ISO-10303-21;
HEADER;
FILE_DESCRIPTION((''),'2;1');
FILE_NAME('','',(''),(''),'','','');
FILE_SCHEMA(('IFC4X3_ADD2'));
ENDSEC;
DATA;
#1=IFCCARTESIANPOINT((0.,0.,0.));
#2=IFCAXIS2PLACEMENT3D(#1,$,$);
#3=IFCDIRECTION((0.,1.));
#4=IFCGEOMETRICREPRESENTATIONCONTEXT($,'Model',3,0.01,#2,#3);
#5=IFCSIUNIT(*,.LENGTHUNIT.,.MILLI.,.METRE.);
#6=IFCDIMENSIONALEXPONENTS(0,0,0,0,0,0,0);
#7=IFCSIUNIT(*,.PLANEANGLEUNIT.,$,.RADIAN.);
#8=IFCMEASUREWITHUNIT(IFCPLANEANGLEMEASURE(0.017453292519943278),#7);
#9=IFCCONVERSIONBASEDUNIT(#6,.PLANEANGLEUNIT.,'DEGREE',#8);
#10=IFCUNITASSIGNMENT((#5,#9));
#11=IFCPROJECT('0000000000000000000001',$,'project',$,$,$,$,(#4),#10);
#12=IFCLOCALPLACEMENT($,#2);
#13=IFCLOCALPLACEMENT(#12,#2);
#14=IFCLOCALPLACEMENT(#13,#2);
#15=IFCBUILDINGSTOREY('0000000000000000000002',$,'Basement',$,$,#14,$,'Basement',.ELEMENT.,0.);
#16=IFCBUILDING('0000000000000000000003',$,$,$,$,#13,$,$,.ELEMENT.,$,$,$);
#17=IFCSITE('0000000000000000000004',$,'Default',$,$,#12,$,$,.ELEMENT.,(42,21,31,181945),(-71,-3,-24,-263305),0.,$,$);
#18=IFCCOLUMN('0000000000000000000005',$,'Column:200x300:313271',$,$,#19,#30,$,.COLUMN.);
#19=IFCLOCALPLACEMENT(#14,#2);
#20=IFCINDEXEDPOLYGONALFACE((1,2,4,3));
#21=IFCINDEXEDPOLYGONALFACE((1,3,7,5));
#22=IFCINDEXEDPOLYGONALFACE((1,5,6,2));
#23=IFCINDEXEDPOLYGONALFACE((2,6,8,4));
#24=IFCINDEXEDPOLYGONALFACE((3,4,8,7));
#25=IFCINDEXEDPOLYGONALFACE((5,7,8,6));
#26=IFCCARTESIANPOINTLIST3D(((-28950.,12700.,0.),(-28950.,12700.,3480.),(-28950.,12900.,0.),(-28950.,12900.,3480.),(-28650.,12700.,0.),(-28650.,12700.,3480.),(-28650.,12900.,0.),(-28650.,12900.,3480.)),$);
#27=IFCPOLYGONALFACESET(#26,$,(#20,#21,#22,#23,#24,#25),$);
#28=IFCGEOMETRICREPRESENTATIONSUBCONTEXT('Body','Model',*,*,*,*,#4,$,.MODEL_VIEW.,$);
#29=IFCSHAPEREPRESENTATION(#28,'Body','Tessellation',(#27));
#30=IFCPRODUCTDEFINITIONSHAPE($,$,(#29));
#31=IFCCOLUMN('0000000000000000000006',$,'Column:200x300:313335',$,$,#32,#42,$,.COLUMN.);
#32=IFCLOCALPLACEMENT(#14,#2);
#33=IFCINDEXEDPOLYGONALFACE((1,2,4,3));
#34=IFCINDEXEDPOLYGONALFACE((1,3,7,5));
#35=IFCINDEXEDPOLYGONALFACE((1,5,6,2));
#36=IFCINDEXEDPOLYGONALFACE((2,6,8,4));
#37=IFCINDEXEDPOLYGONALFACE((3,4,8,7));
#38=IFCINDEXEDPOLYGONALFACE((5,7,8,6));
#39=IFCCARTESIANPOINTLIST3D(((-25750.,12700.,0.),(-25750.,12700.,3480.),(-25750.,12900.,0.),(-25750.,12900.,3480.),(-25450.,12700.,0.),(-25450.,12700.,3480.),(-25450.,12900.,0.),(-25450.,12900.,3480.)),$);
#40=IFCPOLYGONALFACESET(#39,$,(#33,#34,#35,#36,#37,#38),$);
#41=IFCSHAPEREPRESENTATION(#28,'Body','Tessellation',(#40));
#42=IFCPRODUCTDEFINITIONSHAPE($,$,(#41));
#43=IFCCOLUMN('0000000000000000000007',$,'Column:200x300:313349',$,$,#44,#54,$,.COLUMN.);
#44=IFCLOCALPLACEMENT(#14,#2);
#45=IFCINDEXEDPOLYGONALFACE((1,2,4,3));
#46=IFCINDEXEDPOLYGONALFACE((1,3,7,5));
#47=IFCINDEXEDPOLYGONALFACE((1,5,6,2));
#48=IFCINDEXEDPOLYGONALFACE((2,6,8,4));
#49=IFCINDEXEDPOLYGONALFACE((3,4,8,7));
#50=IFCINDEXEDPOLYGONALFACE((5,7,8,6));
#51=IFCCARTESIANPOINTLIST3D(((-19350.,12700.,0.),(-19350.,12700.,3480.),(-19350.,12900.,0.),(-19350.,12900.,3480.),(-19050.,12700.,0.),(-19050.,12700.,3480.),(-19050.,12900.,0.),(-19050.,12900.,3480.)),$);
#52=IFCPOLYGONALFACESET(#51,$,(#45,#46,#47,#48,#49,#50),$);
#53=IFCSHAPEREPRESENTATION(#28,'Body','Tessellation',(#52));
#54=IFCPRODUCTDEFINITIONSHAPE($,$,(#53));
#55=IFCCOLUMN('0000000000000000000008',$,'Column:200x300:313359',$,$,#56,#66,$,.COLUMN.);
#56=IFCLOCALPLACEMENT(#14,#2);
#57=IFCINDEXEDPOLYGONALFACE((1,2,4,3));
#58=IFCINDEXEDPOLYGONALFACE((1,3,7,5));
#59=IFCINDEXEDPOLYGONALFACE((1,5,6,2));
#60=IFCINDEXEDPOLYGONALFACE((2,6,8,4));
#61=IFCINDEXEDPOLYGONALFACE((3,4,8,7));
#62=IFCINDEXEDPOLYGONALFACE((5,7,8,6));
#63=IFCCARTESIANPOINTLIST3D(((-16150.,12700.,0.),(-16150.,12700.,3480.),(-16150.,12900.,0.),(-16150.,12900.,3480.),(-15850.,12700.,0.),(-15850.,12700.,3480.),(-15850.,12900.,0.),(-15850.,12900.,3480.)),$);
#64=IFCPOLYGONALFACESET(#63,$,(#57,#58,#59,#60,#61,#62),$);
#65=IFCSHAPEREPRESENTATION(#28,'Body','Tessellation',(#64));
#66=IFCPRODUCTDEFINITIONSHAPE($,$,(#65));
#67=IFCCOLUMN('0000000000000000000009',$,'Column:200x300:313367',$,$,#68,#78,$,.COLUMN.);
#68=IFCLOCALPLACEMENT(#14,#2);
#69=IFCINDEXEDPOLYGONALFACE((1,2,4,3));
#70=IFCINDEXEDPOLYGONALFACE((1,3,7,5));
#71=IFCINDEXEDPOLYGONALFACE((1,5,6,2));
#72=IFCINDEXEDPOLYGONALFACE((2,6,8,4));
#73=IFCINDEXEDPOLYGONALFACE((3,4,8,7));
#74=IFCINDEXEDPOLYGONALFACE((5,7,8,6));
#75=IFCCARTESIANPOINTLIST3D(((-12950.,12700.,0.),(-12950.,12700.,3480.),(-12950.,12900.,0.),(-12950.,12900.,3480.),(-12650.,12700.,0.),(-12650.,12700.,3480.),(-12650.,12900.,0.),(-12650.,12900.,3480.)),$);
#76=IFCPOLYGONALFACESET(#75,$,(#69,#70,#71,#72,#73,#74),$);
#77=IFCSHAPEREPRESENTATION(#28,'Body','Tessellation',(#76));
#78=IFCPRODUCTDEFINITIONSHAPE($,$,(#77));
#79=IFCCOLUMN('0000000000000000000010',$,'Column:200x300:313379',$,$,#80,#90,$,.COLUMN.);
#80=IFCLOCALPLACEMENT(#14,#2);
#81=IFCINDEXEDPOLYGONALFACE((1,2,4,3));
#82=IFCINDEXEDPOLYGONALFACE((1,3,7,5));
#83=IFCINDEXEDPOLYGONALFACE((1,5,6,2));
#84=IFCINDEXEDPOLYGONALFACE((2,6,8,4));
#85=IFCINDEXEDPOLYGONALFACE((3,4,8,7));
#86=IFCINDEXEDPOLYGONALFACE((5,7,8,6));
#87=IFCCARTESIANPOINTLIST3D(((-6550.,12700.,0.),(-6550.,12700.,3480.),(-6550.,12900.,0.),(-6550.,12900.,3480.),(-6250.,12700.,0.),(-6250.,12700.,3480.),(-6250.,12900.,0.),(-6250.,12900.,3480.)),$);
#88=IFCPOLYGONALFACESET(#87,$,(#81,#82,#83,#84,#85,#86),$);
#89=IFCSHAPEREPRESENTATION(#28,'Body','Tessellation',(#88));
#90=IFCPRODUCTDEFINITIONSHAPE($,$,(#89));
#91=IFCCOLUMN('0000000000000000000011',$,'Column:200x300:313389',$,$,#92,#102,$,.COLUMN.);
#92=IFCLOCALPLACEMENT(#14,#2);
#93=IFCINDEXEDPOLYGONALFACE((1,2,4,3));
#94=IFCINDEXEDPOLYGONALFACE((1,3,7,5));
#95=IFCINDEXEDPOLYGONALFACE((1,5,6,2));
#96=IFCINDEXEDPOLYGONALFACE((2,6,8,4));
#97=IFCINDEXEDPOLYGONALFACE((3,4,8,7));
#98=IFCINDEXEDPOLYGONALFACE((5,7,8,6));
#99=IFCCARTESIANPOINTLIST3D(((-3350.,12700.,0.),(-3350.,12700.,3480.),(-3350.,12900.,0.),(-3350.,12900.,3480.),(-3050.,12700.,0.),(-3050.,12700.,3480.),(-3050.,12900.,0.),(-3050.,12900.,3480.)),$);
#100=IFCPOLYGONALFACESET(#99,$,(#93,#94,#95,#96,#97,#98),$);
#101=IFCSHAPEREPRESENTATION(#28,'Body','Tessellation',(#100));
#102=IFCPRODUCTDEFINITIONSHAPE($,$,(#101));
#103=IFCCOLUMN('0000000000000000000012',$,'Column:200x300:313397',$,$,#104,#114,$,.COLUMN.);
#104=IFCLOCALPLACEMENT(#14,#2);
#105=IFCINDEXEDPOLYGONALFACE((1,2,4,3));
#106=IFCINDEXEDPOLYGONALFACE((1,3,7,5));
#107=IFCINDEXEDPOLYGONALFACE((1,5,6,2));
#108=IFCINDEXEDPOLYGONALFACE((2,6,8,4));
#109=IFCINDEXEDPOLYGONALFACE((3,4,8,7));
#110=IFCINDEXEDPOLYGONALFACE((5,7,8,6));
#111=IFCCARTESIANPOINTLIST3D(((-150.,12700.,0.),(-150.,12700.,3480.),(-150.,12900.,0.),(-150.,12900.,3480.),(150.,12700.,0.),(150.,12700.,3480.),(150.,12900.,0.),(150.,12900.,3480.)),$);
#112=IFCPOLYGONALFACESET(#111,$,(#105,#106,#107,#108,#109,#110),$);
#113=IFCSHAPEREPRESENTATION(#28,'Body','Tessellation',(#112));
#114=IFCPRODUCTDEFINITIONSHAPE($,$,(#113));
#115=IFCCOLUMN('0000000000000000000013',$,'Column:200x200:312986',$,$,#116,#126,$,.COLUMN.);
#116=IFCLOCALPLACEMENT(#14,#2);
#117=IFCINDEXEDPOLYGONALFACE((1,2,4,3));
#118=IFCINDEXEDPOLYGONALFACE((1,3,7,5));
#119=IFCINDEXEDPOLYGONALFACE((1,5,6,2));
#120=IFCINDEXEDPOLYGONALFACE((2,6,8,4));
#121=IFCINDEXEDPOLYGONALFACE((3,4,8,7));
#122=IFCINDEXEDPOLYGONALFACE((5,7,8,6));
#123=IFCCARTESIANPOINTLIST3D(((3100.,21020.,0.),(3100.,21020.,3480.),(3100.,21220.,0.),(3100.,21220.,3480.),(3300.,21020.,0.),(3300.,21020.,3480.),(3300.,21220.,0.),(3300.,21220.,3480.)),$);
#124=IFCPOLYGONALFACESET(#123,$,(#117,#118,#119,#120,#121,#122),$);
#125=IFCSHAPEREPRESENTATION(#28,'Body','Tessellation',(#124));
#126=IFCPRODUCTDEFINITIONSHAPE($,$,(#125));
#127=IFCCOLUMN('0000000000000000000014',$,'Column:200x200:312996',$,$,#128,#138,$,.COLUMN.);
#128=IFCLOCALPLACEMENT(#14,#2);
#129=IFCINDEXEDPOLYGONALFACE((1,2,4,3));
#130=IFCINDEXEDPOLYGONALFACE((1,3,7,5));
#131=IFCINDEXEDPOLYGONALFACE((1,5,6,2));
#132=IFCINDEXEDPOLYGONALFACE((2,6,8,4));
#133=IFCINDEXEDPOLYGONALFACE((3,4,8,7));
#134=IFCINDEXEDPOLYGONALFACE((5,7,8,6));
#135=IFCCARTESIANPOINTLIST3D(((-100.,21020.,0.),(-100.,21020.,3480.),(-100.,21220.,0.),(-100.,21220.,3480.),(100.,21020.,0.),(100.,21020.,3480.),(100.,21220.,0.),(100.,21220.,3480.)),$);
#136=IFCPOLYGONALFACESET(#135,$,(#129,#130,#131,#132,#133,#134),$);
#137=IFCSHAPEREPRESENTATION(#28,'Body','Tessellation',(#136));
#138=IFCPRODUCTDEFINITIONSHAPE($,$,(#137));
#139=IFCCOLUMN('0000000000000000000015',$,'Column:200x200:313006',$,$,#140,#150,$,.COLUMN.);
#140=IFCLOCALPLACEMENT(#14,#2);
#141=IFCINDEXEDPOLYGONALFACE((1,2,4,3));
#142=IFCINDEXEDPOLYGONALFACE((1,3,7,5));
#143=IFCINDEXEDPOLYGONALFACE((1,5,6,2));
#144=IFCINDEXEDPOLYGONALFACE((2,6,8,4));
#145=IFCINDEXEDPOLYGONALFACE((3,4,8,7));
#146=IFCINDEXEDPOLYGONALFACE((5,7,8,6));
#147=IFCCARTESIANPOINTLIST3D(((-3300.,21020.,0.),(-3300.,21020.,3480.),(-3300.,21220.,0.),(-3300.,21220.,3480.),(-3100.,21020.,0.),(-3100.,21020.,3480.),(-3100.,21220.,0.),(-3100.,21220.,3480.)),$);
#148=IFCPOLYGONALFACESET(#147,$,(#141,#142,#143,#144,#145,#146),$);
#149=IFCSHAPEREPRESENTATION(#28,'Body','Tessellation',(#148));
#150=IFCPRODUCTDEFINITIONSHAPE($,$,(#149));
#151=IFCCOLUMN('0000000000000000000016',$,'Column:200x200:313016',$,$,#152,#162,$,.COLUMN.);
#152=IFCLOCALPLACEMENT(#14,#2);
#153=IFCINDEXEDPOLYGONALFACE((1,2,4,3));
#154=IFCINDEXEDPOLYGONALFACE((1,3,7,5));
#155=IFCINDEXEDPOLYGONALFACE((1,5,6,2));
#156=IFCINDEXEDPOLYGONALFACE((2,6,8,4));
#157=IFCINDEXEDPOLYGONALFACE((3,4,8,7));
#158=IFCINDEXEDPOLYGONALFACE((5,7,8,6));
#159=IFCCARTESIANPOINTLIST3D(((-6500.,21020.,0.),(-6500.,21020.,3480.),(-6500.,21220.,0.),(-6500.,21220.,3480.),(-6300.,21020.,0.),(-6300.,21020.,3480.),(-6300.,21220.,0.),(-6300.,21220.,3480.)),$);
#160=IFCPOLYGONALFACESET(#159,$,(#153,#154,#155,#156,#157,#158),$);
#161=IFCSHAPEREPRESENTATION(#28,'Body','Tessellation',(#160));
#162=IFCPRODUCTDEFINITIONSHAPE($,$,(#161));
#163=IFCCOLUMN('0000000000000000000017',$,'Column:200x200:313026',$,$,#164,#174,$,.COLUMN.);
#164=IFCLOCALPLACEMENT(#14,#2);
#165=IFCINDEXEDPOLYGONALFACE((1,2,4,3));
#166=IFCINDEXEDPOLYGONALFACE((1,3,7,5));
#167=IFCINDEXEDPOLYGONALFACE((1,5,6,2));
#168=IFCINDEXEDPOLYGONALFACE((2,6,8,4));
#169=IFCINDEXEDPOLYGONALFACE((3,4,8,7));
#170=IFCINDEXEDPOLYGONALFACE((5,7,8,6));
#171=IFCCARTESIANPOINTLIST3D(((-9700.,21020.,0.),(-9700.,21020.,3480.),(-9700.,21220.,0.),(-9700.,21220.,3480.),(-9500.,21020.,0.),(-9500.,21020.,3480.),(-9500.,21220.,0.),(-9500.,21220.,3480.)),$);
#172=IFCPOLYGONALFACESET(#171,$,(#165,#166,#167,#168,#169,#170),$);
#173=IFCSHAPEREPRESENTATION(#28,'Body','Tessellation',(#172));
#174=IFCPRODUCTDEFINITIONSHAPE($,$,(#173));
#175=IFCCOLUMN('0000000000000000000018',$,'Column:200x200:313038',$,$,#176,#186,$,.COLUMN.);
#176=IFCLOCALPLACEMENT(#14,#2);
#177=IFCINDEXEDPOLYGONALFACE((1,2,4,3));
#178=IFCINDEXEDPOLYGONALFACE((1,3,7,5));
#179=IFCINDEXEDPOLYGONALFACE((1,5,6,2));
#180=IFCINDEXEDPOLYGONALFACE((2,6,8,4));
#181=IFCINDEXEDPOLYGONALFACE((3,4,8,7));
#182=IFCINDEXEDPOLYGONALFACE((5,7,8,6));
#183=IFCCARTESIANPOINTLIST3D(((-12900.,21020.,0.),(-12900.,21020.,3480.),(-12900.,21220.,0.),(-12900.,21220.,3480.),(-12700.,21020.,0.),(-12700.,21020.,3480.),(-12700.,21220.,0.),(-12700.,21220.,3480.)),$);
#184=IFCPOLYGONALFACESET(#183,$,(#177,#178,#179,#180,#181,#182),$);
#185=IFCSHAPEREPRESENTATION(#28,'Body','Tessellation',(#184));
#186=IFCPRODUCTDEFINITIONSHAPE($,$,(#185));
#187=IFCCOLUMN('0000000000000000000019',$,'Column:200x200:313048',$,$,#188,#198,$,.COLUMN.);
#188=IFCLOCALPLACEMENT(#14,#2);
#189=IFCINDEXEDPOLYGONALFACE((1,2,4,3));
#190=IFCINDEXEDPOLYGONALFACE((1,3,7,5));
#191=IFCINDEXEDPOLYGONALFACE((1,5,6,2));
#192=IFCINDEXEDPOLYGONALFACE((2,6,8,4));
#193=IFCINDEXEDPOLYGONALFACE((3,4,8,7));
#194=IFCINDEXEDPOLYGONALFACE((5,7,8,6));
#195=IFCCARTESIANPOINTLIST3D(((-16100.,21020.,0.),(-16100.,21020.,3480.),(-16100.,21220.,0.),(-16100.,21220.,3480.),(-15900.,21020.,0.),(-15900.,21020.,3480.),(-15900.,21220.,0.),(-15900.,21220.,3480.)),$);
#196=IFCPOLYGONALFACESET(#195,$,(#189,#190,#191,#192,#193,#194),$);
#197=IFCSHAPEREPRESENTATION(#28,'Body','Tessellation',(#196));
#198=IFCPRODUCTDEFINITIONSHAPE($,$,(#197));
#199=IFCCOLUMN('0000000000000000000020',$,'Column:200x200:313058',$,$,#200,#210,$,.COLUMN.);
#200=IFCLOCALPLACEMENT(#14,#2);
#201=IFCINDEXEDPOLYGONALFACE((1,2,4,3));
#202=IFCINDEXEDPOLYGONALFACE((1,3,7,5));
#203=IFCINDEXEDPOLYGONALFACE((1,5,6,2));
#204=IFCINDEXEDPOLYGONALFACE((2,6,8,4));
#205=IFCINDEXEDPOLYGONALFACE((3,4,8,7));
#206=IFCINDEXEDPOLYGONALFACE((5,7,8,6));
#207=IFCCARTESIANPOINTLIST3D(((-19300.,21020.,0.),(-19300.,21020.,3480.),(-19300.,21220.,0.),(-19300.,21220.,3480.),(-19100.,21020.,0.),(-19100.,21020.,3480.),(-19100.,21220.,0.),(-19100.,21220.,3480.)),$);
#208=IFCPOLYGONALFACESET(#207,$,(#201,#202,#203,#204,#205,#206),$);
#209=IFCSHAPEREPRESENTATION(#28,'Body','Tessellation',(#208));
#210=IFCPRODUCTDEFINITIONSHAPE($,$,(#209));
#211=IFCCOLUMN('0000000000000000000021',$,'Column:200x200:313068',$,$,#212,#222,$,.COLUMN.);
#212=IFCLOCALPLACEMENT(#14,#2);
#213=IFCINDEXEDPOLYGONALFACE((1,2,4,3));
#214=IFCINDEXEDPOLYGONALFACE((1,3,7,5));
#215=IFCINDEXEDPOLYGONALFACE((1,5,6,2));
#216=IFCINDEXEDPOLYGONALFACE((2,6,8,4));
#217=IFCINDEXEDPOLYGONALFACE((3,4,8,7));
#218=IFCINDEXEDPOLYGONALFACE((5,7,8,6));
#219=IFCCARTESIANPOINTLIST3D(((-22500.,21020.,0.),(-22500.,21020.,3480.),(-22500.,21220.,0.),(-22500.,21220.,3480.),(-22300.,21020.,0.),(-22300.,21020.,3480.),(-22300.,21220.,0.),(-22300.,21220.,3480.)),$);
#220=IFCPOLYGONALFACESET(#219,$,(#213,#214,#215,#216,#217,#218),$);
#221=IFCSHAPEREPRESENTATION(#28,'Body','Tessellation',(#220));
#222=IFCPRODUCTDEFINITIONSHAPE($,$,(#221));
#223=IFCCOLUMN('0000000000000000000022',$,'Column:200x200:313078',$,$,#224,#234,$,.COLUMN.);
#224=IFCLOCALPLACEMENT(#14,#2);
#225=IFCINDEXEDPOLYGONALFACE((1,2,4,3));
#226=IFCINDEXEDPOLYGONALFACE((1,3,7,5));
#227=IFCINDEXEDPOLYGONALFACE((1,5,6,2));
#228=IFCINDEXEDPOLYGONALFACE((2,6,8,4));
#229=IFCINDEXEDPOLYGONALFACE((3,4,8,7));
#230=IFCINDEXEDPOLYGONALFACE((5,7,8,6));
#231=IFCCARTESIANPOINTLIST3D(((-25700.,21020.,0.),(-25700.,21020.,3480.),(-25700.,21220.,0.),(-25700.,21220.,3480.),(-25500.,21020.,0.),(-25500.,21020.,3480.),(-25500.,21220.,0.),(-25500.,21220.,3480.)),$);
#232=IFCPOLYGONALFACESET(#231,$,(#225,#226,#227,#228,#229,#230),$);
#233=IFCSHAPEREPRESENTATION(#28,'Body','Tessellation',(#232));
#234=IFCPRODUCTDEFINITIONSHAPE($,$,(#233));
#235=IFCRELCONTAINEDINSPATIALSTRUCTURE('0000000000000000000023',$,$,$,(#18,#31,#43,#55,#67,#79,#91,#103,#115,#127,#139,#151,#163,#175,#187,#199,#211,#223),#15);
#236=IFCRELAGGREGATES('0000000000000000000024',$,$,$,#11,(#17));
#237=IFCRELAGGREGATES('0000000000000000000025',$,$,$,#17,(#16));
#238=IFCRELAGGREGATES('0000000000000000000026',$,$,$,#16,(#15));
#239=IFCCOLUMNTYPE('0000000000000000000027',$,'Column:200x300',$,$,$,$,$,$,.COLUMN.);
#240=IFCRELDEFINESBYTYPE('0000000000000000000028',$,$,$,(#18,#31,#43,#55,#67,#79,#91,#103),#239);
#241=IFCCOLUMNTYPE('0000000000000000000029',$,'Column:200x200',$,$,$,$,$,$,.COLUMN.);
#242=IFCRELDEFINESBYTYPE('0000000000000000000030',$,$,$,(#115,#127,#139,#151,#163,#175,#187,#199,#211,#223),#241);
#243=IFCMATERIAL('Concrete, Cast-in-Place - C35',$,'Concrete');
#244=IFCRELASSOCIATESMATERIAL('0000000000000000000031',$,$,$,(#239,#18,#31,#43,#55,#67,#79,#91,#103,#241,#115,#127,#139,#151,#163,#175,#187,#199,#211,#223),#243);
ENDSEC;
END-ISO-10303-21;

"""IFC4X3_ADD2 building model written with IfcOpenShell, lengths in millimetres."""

from ifc_helpers import new_model, entity, si_unit, converted_unit, direction, frame, frame_2d, origin, origin_2d_with_axis, place, context, subcontext, project, spatial, rectangle, extrude, source, transform, mapped, material, material_profile, profile_set, profile_usage, type_object, type_shapes, element, save


model = new_model("IFC4X3_ADD2")

# Units and contexts
model_context = context("Model", 3, precision=0.01, world=origin(), true_north=direction((0.0, 1.0)))
body_context = subcontext(model_context, "Body", "Model", "MODEL_VIEW")
ifc_project = project(units=[si_unit("LENGTHUNIT", "METRE", prefix="MILLI"), converted_unit("PLANEANGLEUNIT", "DEGREE", entity("IfcPlaneAngleMeasure", 0.017453292519943278), si_unit("PLANEANGLEUNIT", "RADIAN"), dimensions=[0, 0, 0, 0, 0, 0, 0])], contexts=[model_context])

# Site, building, storey
site_placement = place(None, origin())
site = spatial("IfcSite", under=ifc_project, at=site_placement, Name="Default", CompositionType="ELEMENT", RefLatitude=(42, 21, 31, 181945), RefLongitude=(-71, -3, -24, -263305), RefElevation=0.0)
building_placement = place(site_placement, origin())
building = spatial("IfcBuilding", under=site, at=building_placement, CompositionType="ELEMENT")
storey_placement = place(building_placement, origin())
storey = spatial("IfcBuildingStorey", under=building, at=storey_placement, Name="Basement", LongName="Basement", CompositionType="ELEMENT", Elevation=0.0)

# Columns
ifc_material = material(Name="Concrete, Cast-in-Place - C35", Category="Concrete")
ifc_material_profile_1 = material_profile(ifc_material, rectangle(XDim=300.0, YDim=200.0, at=origin_2d_with_axis()), Name="200x300")
ifc_profile_set_1 = profile_set([ifc_material_profile_1], Name="200x300")
ifc_profile_usage_1 = profile_usage(ifc_profile_set_1)
column_type_1 = type_object("IfcColumnType", Name="Column:200x300", PredefinedType="COLUMN", material=ifc_profile_set_1)
shared_shape_1 = source(origin(), body_context, "Body", "SweptSolid", [
    extrude(rectangle(XDim=300.0, YDim=200.0, at=origin_2d_with_axis()), frame((-50.0, 0.0, 0.0), z_axis=(0.0, 0.0, 1.0), x_axis=(-1.0, 0.0, 0.0)), (0.0, 0.0, 1.0), 3480.0),
])
type_shapes(column_type_1, [shared_shape_1])
for number, where, name in (
    (1, (-28750.0, 12800.0, 0.0), "Column:200x300:313271"),
    (2, (-25550.0, 12800.0, 0.0), "Column:200x300:313335"),
    (3, (-19150.0, 12800.0, 0.0), "Column:200x300:313349"),
    (4, (-15950.0, 12800.0, 0.0), "Column:200x300:313359"),
    (5, (-12750.0, 12800.0, 0.0), "Column:200x300:313367"),
    (6, (-6350.0, 12800.0, 0.0), "Column:200x300:313379"),
    (7, (-3150.0, 12800.0, 0.0), "Column:200x300:313389"),
    (8, (50.0, 12800.0, 0.0), "Column:200x300:313397"),
):
    element("IfcColumn", number, at=place(storey_placement, frame(where)), inside=storey, type_object=column_type_1, material=ifc_profile_usage_1, Name=name, PredefinedType="COLUMN", context=body_context, shape_type="MappedRepresentation", body=[
        mapped(shared_shape_1, transform((0.0, 0.0, 0.0), scale=1.0)),
    ])
ifc_material_profile_2 = material_profile(ifc_material, rectangle(XDim=200.0, YDim=200.0, at=frame_2d((0.0, 0.0), x_axis=(1.0, 0.0))), Name="200x200")
ifc_profile_set_2 = profile_set([ifc_material_profile_2], Name="200x200")
ifc_profile_usage_2 = profile_usage(ifc_profile_set_2)
column_type_2 = type_object("IfcColumnType", Name="Column:200x200", PredefinedType="COLUMN", material=ifc_profile_set_2)
shared_shape_2 = source(origin(), body_context, "Body", "SweptSolid", [
    extrude(rectangle(XDim=200.0, YDim=200.0, at=frame_2d((0.0, 0.0), x_axis=(1.0, 0.0))), frame((0.0, 0.0, 0.0), z_axis=(0.0, 0.0, 1.0), x_axis=(-1.0, 0.0, 0.0)), (0.0, 0.0, 1.0), 3480.0),
])
type_shapes(column_type_2, [shared_shape_2])
for number, where, name in (
    (9, (3200.0, 21120.0, 0.0), "Column:200x200:312986"),
    (10, (0.0, 21120.0, 0.0), "Column:200x200:312996"),
    (11, (-3200.0, 21120.0, 0.0), "Column:200x200:313006"),
    (12, (-6400.0, 21120.0, 0.0), "Column:200x200:313016"),
    (13, (-9600.0, 21120.0, 0.0), "Column:200x200:313026"),
    (14, (-12800.0, 21120.0, 0.0), "Column:200x200:313038"),
    (15, (-16000.0, 21120.0, 0.0), "Column:200x200:313048"),
    (16, (-19200.0, 21120.0, 0.0), "Column:200x200:313058"),
    (17, (-22400.0, 21120.0, 0.0), "Column:200x200:313068"),
    (18, (-25600.0, 21120.0, 0.0), "Column:200x200:313078"),
):
    element("IfcColumn", number, at=place(storey_placement, frame(where)), inside=storey, type_object=column_type_2, material=ifc_profile_usage_2, Name=name, PredefinedType="COLUMN", context=body_context, shape_type="MappedRepresentation", body=[
        mapped(shared_shape_2, transform((0.0, 0.0, 0.0), scale=1.0)),
    ])

save(model, "model.ifc")
